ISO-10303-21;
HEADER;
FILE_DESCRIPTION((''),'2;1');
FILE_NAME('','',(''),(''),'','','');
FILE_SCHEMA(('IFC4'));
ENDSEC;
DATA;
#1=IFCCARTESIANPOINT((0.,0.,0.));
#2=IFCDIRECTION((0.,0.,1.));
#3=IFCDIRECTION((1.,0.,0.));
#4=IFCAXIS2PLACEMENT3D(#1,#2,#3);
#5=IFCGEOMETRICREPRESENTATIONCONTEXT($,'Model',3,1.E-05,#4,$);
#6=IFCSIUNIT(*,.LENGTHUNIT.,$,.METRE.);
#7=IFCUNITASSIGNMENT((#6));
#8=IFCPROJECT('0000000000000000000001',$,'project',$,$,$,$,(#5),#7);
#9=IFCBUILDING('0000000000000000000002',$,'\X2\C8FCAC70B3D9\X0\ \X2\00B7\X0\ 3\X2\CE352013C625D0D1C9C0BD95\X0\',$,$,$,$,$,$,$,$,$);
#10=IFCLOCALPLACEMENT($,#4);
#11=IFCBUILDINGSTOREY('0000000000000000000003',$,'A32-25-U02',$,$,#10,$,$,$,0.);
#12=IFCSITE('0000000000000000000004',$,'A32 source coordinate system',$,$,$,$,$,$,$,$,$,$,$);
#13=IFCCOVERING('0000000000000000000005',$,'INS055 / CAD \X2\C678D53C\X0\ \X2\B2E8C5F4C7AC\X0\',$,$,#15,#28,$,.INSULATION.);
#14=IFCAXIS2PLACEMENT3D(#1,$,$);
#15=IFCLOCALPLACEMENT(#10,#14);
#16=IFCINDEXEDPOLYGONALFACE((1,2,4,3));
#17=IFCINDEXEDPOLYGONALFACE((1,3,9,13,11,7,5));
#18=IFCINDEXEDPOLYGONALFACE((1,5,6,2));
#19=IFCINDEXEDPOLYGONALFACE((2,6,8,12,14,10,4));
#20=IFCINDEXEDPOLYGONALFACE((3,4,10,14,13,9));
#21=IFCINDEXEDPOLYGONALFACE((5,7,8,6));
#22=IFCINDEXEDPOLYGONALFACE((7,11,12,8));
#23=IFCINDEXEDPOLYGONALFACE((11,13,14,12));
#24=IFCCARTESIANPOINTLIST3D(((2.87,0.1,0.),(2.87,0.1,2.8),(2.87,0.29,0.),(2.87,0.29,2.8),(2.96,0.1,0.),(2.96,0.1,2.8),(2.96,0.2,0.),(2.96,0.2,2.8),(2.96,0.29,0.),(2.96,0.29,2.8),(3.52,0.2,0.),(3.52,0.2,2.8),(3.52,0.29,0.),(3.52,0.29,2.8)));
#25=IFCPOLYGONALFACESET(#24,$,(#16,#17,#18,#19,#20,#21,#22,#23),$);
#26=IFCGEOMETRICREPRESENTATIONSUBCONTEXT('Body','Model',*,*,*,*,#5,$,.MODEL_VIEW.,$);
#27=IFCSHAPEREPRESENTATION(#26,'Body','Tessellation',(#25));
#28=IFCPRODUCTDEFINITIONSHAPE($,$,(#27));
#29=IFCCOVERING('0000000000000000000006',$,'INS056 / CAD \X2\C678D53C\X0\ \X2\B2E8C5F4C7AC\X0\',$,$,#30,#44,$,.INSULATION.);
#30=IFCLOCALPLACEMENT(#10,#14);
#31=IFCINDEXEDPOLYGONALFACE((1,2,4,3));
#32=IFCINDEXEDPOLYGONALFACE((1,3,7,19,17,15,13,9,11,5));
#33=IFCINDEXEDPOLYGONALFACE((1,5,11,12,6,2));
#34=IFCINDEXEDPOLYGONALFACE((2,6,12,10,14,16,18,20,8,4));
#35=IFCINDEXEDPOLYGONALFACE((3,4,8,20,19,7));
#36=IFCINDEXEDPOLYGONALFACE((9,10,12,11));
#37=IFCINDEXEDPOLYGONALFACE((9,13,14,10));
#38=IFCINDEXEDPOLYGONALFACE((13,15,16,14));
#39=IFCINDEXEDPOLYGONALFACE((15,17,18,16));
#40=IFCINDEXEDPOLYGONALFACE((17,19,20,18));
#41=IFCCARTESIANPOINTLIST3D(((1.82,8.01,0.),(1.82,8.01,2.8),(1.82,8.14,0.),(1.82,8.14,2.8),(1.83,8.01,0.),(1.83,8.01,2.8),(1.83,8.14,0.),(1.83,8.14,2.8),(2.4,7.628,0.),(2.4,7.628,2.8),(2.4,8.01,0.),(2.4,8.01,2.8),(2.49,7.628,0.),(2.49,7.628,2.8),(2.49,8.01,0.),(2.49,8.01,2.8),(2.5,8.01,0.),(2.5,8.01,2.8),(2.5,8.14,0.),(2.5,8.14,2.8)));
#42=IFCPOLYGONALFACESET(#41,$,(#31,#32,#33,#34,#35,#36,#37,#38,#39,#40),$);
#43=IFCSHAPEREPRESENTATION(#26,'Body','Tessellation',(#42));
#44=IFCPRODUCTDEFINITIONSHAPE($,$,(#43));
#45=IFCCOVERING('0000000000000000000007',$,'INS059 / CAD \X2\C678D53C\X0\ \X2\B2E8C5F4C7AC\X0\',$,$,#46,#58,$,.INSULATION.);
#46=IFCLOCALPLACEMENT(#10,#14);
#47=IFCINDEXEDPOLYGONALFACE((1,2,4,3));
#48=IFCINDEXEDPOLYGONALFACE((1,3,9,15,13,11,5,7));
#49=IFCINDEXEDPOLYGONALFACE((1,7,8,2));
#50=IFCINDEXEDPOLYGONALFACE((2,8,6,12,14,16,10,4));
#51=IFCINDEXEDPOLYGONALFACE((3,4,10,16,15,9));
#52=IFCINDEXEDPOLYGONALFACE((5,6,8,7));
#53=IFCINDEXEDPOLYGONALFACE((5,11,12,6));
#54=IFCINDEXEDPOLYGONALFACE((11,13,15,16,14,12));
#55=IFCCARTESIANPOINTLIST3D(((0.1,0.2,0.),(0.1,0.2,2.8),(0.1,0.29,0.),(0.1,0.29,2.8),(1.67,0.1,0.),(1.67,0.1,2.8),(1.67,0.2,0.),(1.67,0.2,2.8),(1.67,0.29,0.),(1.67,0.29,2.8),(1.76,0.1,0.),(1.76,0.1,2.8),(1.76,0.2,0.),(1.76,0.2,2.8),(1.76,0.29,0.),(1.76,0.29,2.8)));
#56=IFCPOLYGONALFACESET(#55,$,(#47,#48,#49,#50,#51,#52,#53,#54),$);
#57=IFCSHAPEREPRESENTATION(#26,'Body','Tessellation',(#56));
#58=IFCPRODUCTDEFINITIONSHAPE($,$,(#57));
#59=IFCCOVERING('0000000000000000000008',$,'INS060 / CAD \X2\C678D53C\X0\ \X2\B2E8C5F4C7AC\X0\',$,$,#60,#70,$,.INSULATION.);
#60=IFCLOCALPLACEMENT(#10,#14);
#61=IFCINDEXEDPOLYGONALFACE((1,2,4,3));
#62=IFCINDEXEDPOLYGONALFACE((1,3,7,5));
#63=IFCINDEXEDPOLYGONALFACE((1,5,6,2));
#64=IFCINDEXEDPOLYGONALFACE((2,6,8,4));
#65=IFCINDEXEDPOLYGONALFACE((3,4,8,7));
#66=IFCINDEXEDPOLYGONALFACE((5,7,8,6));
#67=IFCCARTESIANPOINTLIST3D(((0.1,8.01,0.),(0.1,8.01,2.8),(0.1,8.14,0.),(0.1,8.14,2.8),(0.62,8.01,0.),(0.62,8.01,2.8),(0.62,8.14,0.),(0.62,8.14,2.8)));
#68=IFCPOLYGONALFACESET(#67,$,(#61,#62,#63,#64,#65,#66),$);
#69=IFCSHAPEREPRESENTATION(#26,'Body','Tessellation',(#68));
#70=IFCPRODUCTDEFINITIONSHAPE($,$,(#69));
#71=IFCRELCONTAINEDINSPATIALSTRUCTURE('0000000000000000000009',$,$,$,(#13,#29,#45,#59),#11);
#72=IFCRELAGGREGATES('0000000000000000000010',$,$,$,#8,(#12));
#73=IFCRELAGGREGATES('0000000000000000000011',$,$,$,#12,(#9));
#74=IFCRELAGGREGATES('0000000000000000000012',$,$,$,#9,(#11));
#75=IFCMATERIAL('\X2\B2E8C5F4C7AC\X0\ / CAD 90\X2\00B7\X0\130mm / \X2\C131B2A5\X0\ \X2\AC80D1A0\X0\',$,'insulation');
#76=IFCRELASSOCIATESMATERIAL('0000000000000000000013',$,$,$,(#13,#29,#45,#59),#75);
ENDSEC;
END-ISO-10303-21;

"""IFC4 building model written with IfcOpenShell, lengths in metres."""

from ifc_helpers import new_model, si_unit, origin, origin_with_axes, place, context, subcontext, project, spatial, polyline, outline, extrude, material, element, save


model = new_model("IFC4")

# Units and contexts
model_context = context("Model", 3, precision=1e-05, world=origin_with_axes())
body_context = subcontext(model_context, "Body", "Model", "MODEL_VIEW")
ifc_project = project(units=[si_unit("LENGTHUNIT", "METRE")], contexts=[model_context])

# Site, building, storey
storey_placement = place(None, origin_with_axes())
site = spatial("IfcSite", under=ifc_project, Name="A32 source coordinate system")
building = spatial("IfcBuilding", under=site, Name="주거동 · 3층–옥탑지붕")
storey = spatial("IfcBuildingStorey", under=building, at=storey_placement, Name="A32-25-U02", Elevation=0.0)

# Coverings
ifc_material = material(Name="단열재 / CAD 90·130mm / 성능 검토", Category="insulation")
covering_1_placement = place(storey_placement, origin_with_axes())
element("IfcCovering", 1, at=covering_1_placement, inside=storey, material=ifc_material, Name="INS055 / CAD 외피 단열재", PredefinedType="INSULATION", context=body_context, shape_type="SweptSolid", body=[
    extrude(outline(polyline([(2.87, 0.29), (2.96, 0.29), (3.52, 0.29), (3.52, 0.2), (2.96, 0.2), (2.96, 0.1), (2.87, 0.1), (2.87, 0.29)])), origin(), (0.0, 0.0, 1.0), 2.8),
])
covering_2_placement = place(storey_placement, origin_with_axes())
element("IfcCovering", 2, at=covering_2_placement, inside=storey, material=ifc_material, Name="INS056 / CAD 외피 단열재", PredefinedType="INSULATION", context=body_context, shape_type="SweptSolid", body=[
    extrude(outline(polyline([(2.49, 7.628), (2.4, 7.628), (2.4, 8.01), (1.83, 8.01), (1.82, 8.01), (1.82, 8.14), (1.83, 8.14), (2.5, 8.14), (2.5, 8.01), (2.49, 8.01), (2.49, 7.628)])), origin(), (0.0, 0.0, 1.0), 2.8),
])
covering_3_placement = place(storey_placement, origin_with_axes())
element("IfcCovering", 3, at=covering_3_placement, inside=storey, material=ifc_material, Name="INS059 / CAD 외피 단열재", PredefinedType="INSULATION", context=body_context, shape_type="SweptSolid", body=[
    extrude(outline(polyline([(1.76, 0.1), (1.67, 0.1), (1.67, 0.2), (0.1, 0.2), (0.1, 0.29), (1.67, 0.29), (1.76, 0.29), (1.76, 0.2), (1.76, 0.1)])), origin(), (0.0, 0.0, 1.0), 2.8),
])
covering_4_placement = place(storey_placement, origin_with_axes())
element("IfcCovering", 4, at=covering_4_placement, inside=storey, material=ifc_material, Name="INS060 / CAD 외피 단열재", PredefinedType="INSULATION", context=body_context, shape_type="SweptSolid", body=[
    extrude(outline(polyline([(0.1, 8.01), (0.1, 8.14), (0.62, 8.14), (0.62, 8.01), (0.1, 8.01)])), origin(), (0.0, 0.0, 1.0), 2.8),
])

save(model, "model.ifc")
